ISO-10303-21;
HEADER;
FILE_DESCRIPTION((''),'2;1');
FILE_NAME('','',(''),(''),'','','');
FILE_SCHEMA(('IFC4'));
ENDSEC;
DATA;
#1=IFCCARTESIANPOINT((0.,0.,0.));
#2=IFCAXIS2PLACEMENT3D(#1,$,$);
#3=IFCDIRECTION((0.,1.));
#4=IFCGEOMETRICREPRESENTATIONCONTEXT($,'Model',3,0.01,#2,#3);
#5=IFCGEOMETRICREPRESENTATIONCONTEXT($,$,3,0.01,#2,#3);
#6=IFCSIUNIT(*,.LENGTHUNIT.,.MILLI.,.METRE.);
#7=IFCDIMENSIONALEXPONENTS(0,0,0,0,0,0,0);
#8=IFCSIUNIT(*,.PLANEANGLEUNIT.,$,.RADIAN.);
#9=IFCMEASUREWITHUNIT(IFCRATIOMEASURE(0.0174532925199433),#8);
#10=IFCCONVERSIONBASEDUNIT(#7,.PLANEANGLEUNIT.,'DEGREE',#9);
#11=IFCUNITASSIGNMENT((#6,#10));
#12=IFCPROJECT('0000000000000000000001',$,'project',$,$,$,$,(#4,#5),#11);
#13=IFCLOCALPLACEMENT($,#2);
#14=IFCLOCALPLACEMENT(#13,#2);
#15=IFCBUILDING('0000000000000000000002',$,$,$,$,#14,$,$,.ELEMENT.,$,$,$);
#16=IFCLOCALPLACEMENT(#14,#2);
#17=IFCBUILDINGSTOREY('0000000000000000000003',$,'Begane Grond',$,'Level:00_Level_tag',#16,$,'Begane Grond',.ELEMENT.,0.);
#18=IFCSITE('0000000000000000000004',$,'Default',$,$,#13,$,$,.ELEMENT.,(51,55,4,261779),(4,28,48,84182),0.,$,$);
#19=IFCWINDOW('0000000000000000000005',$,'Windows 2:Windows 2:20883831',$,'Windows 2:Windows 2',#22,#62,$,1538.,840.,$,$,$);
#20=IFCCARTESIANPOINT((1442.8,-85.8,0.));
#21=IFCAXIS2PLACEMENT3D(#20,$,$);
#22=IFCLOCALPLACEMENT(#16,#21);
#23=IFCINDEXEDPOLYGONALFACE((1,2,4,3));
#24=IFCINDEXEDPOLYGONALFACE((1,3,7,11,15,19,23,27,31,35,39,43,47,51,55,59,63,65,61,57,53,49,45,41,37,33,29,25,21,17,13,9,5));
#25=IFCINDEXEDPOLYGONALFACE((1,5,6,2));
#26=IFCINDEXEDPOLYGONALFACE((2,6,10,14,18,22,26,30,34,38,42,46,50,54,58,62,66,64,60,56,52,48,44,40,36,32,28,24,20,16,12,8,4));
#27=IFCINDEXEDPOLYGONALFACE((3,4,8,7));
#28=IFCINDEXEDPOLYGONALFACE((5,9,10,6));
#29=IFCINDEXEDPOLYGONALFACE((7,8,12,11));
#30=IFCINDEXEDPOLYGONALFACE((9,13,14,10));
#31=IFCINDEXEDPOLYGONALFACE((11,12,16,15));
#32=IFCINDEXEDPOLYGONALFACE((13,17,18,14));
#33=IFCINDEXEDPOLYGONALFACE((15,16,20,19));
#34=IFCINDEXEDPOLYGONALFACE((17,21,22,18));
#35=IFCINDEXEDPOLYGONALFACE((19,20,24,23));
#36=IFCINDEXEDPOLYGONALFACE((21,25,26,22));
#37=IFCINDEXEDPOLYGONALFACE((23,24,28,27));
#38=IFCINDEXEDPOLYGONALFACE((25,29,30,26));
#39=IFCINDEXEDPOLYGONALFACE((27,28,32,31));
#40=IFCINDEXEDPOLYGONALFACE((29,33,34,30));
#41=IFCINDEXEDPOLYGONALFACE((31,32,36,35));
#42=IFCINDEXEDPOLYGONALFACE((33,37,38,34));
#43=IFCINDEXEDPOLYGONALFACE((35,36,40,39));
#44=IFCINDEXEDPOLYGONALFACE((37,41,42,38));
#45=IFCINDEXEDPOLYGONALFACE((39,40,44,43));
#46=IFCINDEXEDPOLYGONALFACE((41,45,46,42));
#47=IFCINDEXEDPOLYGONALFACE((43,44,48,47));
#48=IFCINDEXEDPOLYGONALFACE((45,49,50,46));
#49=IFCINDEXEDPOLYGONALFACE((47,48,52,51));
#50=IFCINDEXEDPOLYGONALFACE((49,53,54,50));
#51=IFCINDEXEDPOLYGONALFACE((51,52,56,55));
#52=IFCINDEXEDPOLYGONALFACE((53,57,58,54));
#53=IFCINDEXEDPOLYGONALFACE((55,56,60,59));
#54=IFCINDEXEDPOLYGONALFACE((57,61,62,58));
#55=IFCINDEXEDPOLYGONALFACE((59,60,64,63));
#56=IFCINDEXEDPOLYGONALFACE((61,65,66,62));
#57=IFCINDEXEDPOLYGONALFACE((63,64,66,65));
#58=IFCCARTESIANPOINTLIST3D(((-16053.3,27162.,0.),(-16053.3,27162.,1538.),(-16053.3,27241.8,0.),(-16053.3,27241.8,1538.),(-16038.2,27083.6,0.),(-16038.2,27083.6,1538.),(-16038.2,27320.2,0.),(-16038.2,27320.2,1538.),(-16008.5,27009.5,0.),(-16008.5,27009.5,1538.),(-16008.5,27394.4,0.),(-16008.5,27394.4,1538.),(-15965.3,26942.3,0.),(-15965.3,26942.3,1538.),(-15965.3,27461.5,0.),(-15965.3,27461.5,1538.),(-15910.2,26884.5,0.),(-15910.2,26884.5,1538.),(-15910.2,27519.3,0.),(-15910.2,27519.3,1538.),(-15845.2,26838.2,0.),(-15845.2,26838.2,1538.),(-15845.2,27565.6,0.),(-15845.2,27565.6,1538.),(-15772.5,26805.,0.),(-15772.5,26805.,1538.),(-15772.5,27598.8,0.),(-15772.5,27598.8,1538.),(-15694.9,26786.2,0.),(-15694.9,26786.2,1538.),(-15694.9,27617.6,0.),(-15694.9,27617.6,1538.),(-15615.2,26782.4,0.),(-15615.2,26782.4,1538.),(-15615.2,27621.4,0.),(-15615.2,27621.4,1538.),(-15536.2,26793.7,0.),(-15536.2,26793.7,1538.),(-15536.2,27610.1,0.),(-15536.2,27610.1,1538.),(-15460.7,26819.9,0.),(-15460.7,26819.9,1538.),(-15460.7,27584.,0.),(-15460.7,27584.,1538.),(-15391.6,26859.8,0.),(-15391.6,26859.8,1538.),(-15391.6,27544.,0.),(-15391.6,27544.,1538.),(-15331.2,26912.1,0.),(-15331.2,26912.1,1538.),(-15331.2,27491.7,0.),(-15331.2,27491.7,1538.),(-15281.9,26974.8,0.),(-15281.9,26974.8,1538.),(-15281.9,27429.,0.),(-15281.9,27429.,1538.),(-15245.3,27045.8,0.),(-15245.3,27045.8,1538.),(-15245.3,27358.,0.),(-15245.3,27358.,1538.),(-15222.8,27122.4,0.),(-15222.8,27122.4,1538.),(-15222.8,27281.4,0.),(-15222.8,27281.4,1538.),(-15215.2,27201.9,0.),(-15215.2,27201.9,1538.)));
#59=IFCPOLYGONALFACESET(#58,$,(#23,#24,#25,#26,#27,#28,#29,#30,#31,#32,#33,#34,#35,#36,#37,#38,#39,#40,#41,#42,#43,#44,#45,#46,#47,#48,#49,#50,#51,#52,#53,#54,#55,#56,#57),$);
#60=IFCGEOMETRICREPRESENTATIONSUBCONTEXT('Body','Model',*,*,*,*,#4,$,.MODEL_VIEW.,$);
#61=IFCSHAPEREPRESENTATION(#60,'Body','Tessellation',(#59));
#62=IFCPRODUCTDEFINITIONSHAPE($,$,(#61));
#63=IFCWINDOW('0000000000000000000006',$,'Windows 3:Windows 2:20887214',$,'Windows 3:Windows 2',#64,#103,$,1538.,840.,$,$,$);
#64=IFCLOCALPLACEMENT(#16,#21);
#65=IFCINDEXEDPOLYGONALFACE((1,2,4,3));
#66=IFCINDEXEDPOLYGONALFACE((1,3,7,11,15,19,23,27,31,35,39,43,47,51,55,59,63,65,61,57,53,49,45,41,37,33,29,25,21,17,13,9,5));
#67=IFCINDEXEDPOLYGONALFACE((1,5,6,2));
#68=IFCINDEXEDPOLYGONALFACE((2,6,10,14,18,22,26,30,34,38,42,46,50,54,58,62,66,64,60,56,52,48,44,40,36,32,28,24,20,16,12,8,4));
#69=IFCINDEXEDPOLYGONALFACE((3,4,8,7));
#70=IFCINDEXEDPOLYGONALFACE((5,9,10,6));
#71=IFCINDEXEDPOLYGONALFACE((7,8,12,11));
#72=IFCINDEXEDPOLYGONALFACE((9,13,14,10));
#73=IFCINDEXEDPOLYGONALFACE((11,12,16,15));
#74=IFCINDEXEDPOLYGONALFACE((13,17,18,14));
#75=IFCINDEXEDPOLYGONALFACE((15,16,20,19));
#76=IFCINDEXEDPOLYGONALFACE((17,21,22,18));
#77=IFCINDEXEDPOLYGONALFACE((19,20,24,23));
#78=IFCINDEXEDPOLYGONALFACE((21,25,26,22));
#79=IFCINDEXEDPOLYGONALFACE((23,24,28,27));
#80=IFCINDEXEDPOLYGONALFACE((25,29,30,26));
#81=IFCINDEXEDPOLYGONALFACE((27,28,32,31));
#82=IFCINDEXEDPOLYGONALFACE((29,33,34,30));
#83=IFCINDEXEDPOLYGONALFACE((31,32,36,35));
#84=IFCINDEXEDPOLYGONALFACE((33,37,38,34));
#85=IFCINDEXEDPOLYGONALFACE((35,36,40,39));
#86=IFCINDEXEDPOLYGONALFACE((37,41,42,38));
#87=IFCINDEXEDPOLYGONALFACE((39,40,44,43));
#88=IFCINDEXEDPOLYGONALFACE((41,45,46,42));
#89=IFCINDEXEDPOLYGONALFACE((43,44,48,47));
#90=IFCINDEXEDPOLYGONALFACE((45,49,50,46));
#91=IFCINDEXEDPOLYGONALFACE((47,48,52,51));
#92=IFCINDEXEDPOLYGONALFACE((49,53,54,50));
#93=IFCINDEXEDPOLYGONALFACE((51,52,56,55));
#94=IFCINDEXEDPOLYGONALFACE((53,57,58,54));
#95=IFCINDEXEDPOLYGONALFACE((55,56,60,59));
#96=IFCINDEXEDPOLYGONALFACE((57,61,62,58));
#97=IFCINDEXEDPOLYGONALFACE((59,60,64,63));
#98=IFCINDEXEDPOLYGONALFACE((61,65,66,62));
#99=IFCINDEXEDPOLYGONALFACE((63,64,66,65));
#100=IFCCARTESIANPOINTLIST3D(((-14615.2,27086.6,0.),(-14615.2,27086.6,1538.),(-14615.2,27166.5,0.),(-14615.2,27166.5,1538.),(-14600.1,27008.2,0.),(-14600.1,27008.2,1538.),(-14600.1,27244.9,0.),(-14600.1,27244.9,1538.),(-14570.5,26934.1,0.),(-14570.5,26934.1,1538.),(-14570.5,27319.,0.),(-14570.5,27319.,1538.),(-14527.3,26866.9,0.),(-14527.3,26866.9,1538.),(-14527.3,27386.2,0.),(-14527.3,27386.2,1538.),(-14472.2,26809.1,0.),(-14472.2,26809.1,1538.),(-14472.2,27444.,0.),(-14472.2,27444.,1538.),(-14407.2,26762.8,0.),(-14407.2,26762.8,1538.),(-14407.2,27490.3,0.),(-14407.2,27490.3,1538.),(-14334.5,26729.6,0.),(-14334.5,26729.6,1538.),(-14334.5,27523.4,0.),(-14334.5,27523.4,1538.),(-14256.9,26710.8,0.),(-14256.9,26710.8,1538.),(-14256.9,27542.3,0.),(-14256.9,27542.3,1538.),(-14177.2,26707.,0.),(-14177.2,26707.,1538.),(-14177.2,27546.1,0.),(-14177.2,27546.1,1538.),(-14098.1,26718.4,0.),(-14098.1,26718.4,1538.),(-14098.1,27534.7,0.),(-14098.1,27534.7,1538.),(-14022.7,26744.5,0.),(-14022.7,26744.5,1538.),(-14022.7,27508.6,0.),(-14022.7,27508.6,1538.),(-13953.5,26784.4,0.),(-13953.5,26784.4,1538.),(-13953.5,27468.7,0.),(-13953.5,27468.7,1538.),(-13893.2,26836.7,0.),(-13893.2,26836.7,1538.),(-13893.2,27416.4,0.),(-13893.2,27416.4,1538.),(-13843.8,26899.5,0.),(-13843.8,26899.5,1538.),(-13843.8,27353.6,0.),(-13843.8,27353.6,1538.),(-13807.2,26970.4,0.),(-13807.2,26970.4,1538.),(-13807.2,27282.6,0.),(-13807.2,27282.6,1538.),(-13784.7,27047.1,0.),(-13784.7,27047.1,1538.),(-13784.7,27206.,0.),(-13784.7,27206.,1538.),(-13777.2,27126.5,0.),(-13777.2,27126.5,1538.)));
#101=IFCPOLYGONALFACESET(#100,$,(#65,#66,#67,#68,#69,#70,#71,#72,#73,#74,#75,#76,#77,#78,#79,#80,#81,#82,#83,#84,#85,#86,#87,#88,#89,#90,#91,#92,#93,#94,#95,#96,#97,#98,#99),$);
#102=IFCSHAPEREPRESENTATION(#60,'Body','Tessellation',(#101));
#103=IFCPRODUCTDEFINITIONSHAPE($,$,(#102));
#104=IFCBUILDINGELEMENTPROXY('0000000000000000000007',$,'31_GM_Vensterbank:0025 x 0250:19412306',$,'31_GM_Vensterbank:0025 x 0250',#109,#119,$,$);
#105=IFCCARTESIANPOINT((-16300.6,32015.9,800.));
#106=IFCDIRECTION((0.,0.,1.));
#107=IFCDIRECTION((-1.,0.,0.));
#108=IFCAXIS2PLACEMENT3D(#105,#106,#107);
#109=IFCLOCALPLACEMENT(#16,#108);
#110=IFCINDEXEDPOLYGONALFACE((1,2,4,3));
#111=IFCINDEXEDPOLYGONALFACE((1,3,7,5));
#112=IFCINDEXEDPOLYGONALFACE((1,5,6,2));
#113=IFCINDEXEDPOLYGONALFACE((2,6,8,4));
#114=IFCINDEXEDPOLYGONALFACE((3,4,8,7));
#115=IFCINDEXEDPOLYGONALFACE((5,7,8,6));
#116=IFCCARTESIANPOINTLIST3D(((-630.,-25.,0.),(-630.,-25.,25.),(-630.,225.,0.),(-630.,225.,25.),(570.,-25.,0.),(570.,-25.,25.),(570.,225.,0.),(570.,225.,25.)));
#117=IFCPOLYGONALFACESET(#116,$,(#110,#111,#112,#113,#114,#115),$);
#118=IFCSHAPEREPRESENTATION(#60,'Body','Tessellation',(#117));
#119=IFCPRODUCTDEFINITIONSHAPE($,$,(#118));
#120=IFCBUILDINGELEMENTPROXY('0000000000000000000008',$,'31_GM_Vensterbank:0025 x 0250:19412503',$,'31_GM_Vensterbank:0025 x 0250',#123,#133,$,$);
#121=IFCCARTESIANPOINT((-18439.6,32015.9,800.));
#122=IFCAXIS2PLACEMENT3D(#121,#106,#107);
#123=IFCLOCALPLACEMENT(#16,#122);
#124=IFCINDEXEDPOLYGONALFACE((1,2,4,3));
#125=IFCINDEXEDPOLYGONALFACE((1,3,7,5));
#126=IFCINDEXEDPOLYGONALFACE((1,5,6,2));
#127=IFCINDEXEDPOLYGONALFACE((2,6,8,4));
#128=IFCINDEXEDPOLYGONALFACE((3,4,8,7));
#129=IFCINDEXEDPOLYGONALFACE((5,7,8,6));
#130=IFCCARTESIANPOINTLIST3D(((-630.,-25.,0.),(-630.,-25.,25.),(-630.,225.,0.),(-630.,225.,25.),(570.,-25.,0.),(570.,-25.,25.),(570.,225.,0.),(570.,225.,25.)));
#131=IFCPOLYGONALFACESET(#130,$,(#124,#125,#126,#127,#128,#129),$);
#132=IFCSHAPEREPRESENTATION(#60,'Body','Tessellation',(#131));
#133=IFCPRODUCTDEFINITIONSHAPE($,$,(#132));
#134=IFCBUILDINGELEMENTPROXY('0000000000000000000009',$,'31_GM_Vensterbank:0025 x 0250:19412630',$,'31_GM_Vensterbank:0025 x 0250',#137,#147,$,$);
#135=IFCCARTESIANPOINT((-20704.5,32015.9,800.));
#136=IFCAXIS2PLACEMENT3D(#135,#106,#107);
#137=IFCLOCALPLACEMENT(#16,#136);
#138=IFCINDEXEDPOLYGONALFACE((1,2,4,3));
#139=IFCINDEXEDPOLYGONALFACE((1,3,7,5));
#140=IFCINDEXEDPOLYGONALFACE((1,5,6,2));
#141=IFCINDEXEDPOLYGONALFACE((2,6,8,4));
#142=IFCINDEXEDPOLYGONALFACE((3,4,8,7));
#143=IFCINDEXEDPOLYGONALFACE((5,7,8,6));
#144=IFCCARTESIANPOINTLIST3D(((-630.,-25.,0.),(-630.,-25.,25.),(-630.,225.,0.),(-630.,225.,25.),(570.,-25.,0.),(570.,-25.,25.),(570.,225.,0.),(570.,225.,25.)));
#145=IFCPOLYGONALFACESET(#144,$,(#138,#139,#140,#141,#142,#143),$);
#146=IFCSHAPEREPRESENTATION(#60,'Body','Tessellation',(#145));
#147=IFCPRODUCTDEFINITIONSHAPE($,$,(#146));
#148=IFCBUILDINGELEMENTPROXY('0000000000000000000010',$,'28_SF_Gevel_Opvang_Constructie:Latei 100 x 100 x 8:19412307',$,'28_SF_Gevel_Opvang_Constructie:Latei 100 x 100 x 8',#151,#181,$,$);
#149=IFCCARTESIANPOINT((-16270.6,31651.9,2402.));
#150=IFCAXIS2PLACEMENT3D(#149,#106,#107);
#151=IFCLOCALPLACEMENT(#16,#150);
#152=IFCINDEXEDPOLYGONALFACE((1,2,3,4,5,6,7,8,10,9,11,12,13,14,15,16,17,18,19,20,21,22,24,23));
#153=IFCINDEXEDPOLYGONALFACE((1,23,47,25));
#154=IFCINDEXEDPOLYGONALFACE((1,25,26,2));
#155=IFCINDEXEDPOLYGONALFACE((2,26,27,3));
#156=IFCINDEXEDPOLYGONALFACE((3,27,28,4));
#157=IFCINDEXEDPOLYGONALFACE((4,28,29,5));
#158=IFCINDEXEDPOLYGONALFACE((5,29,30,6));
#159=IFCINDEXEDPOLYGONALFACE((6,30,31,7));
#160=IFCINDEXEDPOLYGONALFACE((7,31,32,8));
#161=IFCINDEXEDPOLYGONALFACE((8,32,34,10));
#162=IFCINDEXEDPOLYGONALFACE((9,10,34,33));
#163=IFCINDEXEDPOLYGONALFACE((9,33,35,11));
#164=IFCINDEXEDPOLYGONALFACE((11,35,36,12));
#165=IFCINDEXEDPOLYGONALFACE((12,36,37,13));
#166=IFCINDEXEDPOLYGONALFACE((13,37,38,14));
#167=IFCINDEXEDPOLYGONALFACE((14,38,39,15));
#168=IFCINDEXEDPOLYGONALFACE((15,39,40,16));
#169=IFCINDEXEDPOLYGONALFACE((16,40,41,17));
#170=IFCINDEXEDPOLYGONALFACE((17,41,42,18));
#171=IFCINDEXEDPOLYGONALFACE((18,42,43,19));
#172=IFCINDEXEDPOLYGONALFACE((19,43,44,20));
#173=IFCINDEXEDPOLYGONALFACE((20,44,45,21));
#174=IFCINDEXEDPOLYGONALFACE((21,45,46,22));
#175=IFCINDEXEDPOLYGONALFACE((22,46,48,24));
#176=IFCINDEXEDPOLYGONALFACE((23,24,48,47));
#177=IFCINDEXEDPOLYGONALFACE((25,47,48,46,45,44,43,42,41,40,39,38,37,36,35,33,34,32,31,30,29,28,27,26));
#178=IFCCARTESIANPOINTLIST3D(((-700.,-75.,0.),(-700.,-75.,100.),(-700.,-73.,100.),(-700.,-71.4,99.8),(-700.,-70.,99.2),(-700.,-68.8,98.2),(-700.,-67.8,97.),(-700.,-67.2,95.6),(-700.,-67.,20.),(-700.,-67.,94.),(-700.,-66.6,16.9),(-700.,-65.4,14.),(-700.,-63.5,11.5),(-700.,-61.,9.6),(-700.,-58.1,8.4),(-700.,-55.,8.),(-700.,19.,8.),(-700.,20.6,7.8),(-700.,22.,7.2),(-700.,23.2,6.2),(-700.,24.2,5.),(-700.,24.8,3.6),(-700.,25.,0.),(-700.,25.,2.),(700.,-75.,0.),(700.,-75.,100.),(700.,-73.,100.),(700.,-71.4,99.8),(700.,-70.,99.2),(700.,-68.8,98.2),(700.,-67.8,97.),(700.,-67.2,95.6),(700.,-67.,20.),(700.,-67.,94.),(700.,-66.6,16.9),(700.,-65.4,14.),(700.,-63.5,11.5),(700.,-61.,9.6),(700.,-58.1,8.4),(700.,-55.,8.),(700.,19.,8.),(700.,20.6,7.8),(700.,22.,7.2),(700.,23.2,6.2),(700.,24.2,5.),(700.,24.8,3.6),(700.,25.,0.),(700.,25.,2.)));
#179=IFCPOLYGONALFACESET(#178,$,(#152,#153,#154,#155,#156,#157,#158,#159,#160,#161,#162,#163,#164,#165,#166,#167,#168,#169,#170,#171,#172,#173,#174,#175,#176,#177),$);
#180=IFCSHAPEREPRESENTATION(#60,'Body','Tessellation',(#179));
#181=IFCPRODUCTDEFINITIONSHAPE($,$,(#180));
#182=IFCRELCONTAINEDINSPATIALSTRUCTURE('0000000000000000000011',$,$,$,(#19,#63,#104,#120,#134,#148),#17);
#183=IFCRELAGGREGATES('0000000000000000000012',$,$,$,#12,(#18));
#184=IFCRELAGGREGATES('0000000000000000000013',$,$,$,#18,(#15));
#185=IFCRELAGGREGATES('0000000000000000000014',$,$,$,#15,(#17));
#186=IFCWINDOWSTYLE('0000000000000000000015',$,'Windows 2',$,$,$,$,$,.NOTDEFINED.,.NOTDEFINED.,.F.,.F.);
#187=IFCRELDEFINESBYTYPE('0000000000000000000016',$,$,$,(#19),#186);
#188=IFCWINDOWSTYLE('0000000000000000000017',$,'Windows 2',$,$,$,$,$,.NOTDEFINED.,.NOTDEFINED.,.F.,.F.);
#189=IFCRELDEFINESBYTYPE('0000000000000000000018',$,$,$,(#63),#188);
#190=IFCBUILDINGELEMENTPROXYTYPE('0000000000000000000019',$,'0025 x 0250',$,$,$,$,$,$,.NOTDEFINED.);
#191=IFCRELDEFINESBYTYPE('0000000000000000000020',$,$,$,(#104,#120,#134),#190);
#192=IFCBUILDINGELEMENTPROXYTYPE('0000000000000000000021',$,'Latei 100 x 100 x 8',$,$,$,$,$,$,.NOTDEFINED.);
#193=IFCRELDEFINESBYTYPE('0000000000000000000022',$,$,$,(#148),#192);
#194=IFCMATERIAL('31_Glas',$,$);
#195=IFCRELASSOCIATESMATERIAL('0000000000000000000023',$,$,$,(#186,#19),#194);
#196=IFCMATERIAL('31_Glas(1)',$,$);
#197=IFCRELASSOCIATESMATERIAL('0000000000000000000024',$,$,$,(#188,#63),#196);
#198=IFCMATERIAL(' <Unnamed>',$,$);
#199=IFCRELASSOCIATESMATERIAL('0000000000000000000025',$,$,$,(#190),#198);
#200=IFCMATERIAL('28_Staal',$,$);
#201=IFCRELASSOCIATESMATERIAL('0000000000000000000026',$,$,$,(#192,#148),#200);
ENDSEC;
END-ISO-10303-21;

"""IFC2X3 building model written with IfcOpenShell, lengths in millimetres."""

from ifc_helpers import new_model, entity, si_unit, converted_unit, direction, frame, frame_2d, origin, origin_2d_with_axis, place, context, subcontext, project, spatial, polyline, circle_curve, parameter, trimmed, segment, composite_curve, rectangle, circle, outline, extrude, source, transform, mapped, material, type_object, type_shapes, element, save


model = new_model("IFC2X3")

# Units and contexts
model_context = context("Model", 3, precision=0.01, world=origin(), true_north=direction((0.0, 1.0)))
context_of_model = context(None, 3, precision=0.01, world=origin(), true_north=direction((0.0, 1.0)))
body_context = subcontext(model_context, "Body", "Model", "MODEL_VIEW")
ifc_project = project(units=[si_unit("LENGTHUNIT", "METRE", prefix="MILLI"), converted_unit("PLANEANGLEUNIT", "DEGREE", entity("IfcRatioMeasure", 0.0174532925199433), si_unit("PLANEANGLEUNIT", "RADIAN"), dimensions=[0, 0, 0, 0, 0, 0, 0])], contexts=[model_context, context_of_model])

# Site, building, storey
site_placement = place(None, origin())
site = spatial("IfcSite", under=ifc_project, at=site_placement, Name="Default", CompositionType="ELEMENT", RefLatitude=(51, 55, 4, 261779), RefLongitude=(4, 28, 48, 84182), RefElevation=0.0)
building_placement = place(site_placement, origin())
building = spatial("IfcBuilding", under=site, at=building_placement, CompositionType="ELEMENT")
storey_placement = place(building_placement, origin())
storey = spatial("IfcBuildingStorey", under=building, at=storey_placement, Name="Begane Grond", ObjectType="Level:00_Level_tag", LongName="Begane Grond", CompositionType="ELEMENT", Elevation=0.0)

# Windows
ifc_material_1 = material(Name="31_Glas")
window_style_1 = type_object("IfcWindowStyle", Name="Windows 2", ConstructionType="NOTDEFINED", OperationType="NOTDEFINED", ParameterTakesPrecedence=False, Sizeable=False, material=ifc_material_1)
shared_shape_1 = source(origin(), body_context, "Body", "SweptSolid", [
    extrude(circle(Radius=420.0, at=origin_2d_with_axis()), frame((-15635.2, 27201.9, 0.0)), (0.0, 0.0, 1.0), 1538.0),
])
type_shapes(window_style_1, [shared_shape_1])
window_1_placement = place(storey_placement, frame((1442.8, -85.8, 0.0)))
element("IfcWindow", 1, at=window_1_placement, inside=storey, type_object=window_style_1, material=ifc_material_1, Name="Windows 2:Windows 2:20883831", ObjectType="Windows 2:Windows 2", OverallHeight=1538.0, OverallWidth=840.0, context=body_context, shape_type="MappedRepresentation", body=[
    mapped(shared_shape_1, transform((0.0, 0.0, 0.0), scale=1.0)),
])
ifc_material_2 = material(Name="31_Glas(1)")
window_style_2 = type_object("IfcWindowStyle", Name="Windows 2", ConstructionType="NOTDEFINED", OperationType="NOTDEFINED", ParameterTakesPrecedence=False, Sizeable=False, material=ifc_material_2)
shared_shape_2 = source(origin(), body_context, "Body", "SweptSolid", [
    extrude(circle(Radius=420.0, at=origin_2d_with_axis()), frame((-14197.2, 27126.5, 0.0)), (0.0, 0.0, 1.0), 1538.0),
])
type_shapes(window_style_2, [shared_shape_2])
window_2_placement = place(storey_placement, frame((1442.8, -85.8, 0.0)))
element("IfcWindow", 2, at=window_2_placement, inside=storey, type_object=window_style_2, material=ifc_material_2, Name="Windows 3:Windows 2:20887214", ObjectType="Windows 3:Windows 2", OverallHeight=1538.0, OverallWidth=840.0, context=body_context, shape_type="MappedRepresentation", body=[
    mapped(shared_shape_2, transform((0.0, 0.0, 0.0), scale=1.0)),
])

# Building element proxies
ifc_material_3 = material(Name=" <Unnamed>")
building_element_proxy_type_1 = type_object("IfcBuildingElementProxyType", Name="0025 x 0250", PredefinedType="NOTDEFINED", material=ifc_material_3)
shared_shape_3 = source(origin(), body_context, "Body", "SweptSolid", [
    extrude(rectangle(XDim=1200.0, YDim=250.0, at=origin_2d_with_axis()), frame((-30.0, 100.0, 0.0)), (0.0, 0.0, 1.0), 25.0),
])
type_shapes(building_element_proxy_type_1, [shared_shape_3])
for number, where, z_axis, x_axis, name in (
    (3, (-16300.6, 32015.9, 800.0), (0.0, 0.0, 1.0), (-1.0, 0.0, 0.0), "31_GM_Vensterbank:0025 x 0250:19412306"),
    (4, (-18439.6, 32015.9, 800.0), (0.0, 0.0, 1.0), (-1.0, 0.0, 0.0), "31_GM_Vensterbank:0025 x 0250:19412503"),
    (5, (-20704.5, 32015.9, 800.0), (0.0, 0.0, 1.0), (-1.0, 0.0, 0.0), "31_GM_Vensterbank:0025 x 0250:19412630"),
):
    element("IfcBuildingElementProxy", number, at=place(storey_placement, frame(where, z_axis=z_axis, x_axis=x_axis)), inside=storey, type_object=building_element_proxy_type_1, Name=name, ObjectType="31_GM_Vensterbank:0025 x 0250", context=body_context, shape_type="MappedRepresentation", body=[
        mapped(shared_shape_3, transform((0.0, 0.0, 0.0), scale=1.0)),
    ])
ifc_material_4 = material(Name="28_Staal")
building_element_proxy_type_2 = type_object("IfcBuildingElementProxyType", Name="Latei 100 x 100 x 8", PredefinedType="NOTDEFINED", material=ifc_material_4)
shared_shape_4 = source(origin(), body_context, "Body", "SweptSolid", [
    extrude(outline(composite_curve([segment(polyline([(-36.9, -36.9), (63.1, -36.9)]), True, "CONTINUOUS"), segment(polyline([(63.1, -36.9), (63.1, -34.9)]), True, "CONTINUOUS"), segment(trimmed(circle_curve(frame_2d((57.1, -34.9), x_axis=(1.0, 0.0)), 6.0), [parameter(0.0)], [parameter(90.0)], True, "PARAMETER"), True, "CONTINUOUS"), segment(polyline([(57.1, -28.9), (-16.9, -28.9)]), True, "CONTINUOUS"), segment(trimmed(circle_curve(frame_2d((-16.9, -16.9), x_axis=(1.0, 0.0)), 12.0), [parameter(180.0)], [parameter(270.0)], True, "PARAMETER"), False, "CONTINUOUS"), segment(polyline([(-28.9, -16.9), (-28.9, 57.1)]), True, "CONTINUOUS"), segment(trimmed(circle_curve(frame_2d((-34.9, 57.1), x_axis=(1.0, 0.0)), 6.0), [parameter(0.0)], [parameter(90.0)], True, "PARAMETER"), True, "CONTINUOUS"), segment(polyline([(-34.9, 63.1), (-36.9, 63.1)]), True, "CONTINUOUS"), segment(polyline([(-36.9, 63.1), (-36.9, -36.9)]), True, "CONTINUOUS")], self_intersect=False)), frame((-700.0, -38.1, 36.9), z_axis=(1.0, 0.0, 0.0), x_axis=(0.0, 1.0, 0.0)), (0.0, 0.0, 1.0), 1400.0),
])
type_shapes(building_element_proxy_type_2, [shared_shape_4])
for number, where, z_axis, x_axis, name in (
    (6, (-16270.6, 31651.9, 2402.0), (0.0, 0.0, 1.0), (-1.0, 0.0, 0.0), "28_SF_Gevel_Opvang_Constructie:Latei 100 x 100 x 8:19412307"),
):
    element("IfcBuildingElementProxy", number, at=place(storey_placement, frame(where, z_axis=z_axis, x_axis=x_axis)), inside=storey, type_object=building_element_proxy_type_2, material=ifc_material_4, Name=name, ObjectType="28_SF_Gevel_Opvang_Constructie:Latei 100 x 100 x 8", context=body_context, shape_type="MappedRepresentation", body=[
        mapped(shared_shape_4, transform((0.0, 0.0, 0.0), scale=1.0)),
    ])

save(model, "model.ifc")
